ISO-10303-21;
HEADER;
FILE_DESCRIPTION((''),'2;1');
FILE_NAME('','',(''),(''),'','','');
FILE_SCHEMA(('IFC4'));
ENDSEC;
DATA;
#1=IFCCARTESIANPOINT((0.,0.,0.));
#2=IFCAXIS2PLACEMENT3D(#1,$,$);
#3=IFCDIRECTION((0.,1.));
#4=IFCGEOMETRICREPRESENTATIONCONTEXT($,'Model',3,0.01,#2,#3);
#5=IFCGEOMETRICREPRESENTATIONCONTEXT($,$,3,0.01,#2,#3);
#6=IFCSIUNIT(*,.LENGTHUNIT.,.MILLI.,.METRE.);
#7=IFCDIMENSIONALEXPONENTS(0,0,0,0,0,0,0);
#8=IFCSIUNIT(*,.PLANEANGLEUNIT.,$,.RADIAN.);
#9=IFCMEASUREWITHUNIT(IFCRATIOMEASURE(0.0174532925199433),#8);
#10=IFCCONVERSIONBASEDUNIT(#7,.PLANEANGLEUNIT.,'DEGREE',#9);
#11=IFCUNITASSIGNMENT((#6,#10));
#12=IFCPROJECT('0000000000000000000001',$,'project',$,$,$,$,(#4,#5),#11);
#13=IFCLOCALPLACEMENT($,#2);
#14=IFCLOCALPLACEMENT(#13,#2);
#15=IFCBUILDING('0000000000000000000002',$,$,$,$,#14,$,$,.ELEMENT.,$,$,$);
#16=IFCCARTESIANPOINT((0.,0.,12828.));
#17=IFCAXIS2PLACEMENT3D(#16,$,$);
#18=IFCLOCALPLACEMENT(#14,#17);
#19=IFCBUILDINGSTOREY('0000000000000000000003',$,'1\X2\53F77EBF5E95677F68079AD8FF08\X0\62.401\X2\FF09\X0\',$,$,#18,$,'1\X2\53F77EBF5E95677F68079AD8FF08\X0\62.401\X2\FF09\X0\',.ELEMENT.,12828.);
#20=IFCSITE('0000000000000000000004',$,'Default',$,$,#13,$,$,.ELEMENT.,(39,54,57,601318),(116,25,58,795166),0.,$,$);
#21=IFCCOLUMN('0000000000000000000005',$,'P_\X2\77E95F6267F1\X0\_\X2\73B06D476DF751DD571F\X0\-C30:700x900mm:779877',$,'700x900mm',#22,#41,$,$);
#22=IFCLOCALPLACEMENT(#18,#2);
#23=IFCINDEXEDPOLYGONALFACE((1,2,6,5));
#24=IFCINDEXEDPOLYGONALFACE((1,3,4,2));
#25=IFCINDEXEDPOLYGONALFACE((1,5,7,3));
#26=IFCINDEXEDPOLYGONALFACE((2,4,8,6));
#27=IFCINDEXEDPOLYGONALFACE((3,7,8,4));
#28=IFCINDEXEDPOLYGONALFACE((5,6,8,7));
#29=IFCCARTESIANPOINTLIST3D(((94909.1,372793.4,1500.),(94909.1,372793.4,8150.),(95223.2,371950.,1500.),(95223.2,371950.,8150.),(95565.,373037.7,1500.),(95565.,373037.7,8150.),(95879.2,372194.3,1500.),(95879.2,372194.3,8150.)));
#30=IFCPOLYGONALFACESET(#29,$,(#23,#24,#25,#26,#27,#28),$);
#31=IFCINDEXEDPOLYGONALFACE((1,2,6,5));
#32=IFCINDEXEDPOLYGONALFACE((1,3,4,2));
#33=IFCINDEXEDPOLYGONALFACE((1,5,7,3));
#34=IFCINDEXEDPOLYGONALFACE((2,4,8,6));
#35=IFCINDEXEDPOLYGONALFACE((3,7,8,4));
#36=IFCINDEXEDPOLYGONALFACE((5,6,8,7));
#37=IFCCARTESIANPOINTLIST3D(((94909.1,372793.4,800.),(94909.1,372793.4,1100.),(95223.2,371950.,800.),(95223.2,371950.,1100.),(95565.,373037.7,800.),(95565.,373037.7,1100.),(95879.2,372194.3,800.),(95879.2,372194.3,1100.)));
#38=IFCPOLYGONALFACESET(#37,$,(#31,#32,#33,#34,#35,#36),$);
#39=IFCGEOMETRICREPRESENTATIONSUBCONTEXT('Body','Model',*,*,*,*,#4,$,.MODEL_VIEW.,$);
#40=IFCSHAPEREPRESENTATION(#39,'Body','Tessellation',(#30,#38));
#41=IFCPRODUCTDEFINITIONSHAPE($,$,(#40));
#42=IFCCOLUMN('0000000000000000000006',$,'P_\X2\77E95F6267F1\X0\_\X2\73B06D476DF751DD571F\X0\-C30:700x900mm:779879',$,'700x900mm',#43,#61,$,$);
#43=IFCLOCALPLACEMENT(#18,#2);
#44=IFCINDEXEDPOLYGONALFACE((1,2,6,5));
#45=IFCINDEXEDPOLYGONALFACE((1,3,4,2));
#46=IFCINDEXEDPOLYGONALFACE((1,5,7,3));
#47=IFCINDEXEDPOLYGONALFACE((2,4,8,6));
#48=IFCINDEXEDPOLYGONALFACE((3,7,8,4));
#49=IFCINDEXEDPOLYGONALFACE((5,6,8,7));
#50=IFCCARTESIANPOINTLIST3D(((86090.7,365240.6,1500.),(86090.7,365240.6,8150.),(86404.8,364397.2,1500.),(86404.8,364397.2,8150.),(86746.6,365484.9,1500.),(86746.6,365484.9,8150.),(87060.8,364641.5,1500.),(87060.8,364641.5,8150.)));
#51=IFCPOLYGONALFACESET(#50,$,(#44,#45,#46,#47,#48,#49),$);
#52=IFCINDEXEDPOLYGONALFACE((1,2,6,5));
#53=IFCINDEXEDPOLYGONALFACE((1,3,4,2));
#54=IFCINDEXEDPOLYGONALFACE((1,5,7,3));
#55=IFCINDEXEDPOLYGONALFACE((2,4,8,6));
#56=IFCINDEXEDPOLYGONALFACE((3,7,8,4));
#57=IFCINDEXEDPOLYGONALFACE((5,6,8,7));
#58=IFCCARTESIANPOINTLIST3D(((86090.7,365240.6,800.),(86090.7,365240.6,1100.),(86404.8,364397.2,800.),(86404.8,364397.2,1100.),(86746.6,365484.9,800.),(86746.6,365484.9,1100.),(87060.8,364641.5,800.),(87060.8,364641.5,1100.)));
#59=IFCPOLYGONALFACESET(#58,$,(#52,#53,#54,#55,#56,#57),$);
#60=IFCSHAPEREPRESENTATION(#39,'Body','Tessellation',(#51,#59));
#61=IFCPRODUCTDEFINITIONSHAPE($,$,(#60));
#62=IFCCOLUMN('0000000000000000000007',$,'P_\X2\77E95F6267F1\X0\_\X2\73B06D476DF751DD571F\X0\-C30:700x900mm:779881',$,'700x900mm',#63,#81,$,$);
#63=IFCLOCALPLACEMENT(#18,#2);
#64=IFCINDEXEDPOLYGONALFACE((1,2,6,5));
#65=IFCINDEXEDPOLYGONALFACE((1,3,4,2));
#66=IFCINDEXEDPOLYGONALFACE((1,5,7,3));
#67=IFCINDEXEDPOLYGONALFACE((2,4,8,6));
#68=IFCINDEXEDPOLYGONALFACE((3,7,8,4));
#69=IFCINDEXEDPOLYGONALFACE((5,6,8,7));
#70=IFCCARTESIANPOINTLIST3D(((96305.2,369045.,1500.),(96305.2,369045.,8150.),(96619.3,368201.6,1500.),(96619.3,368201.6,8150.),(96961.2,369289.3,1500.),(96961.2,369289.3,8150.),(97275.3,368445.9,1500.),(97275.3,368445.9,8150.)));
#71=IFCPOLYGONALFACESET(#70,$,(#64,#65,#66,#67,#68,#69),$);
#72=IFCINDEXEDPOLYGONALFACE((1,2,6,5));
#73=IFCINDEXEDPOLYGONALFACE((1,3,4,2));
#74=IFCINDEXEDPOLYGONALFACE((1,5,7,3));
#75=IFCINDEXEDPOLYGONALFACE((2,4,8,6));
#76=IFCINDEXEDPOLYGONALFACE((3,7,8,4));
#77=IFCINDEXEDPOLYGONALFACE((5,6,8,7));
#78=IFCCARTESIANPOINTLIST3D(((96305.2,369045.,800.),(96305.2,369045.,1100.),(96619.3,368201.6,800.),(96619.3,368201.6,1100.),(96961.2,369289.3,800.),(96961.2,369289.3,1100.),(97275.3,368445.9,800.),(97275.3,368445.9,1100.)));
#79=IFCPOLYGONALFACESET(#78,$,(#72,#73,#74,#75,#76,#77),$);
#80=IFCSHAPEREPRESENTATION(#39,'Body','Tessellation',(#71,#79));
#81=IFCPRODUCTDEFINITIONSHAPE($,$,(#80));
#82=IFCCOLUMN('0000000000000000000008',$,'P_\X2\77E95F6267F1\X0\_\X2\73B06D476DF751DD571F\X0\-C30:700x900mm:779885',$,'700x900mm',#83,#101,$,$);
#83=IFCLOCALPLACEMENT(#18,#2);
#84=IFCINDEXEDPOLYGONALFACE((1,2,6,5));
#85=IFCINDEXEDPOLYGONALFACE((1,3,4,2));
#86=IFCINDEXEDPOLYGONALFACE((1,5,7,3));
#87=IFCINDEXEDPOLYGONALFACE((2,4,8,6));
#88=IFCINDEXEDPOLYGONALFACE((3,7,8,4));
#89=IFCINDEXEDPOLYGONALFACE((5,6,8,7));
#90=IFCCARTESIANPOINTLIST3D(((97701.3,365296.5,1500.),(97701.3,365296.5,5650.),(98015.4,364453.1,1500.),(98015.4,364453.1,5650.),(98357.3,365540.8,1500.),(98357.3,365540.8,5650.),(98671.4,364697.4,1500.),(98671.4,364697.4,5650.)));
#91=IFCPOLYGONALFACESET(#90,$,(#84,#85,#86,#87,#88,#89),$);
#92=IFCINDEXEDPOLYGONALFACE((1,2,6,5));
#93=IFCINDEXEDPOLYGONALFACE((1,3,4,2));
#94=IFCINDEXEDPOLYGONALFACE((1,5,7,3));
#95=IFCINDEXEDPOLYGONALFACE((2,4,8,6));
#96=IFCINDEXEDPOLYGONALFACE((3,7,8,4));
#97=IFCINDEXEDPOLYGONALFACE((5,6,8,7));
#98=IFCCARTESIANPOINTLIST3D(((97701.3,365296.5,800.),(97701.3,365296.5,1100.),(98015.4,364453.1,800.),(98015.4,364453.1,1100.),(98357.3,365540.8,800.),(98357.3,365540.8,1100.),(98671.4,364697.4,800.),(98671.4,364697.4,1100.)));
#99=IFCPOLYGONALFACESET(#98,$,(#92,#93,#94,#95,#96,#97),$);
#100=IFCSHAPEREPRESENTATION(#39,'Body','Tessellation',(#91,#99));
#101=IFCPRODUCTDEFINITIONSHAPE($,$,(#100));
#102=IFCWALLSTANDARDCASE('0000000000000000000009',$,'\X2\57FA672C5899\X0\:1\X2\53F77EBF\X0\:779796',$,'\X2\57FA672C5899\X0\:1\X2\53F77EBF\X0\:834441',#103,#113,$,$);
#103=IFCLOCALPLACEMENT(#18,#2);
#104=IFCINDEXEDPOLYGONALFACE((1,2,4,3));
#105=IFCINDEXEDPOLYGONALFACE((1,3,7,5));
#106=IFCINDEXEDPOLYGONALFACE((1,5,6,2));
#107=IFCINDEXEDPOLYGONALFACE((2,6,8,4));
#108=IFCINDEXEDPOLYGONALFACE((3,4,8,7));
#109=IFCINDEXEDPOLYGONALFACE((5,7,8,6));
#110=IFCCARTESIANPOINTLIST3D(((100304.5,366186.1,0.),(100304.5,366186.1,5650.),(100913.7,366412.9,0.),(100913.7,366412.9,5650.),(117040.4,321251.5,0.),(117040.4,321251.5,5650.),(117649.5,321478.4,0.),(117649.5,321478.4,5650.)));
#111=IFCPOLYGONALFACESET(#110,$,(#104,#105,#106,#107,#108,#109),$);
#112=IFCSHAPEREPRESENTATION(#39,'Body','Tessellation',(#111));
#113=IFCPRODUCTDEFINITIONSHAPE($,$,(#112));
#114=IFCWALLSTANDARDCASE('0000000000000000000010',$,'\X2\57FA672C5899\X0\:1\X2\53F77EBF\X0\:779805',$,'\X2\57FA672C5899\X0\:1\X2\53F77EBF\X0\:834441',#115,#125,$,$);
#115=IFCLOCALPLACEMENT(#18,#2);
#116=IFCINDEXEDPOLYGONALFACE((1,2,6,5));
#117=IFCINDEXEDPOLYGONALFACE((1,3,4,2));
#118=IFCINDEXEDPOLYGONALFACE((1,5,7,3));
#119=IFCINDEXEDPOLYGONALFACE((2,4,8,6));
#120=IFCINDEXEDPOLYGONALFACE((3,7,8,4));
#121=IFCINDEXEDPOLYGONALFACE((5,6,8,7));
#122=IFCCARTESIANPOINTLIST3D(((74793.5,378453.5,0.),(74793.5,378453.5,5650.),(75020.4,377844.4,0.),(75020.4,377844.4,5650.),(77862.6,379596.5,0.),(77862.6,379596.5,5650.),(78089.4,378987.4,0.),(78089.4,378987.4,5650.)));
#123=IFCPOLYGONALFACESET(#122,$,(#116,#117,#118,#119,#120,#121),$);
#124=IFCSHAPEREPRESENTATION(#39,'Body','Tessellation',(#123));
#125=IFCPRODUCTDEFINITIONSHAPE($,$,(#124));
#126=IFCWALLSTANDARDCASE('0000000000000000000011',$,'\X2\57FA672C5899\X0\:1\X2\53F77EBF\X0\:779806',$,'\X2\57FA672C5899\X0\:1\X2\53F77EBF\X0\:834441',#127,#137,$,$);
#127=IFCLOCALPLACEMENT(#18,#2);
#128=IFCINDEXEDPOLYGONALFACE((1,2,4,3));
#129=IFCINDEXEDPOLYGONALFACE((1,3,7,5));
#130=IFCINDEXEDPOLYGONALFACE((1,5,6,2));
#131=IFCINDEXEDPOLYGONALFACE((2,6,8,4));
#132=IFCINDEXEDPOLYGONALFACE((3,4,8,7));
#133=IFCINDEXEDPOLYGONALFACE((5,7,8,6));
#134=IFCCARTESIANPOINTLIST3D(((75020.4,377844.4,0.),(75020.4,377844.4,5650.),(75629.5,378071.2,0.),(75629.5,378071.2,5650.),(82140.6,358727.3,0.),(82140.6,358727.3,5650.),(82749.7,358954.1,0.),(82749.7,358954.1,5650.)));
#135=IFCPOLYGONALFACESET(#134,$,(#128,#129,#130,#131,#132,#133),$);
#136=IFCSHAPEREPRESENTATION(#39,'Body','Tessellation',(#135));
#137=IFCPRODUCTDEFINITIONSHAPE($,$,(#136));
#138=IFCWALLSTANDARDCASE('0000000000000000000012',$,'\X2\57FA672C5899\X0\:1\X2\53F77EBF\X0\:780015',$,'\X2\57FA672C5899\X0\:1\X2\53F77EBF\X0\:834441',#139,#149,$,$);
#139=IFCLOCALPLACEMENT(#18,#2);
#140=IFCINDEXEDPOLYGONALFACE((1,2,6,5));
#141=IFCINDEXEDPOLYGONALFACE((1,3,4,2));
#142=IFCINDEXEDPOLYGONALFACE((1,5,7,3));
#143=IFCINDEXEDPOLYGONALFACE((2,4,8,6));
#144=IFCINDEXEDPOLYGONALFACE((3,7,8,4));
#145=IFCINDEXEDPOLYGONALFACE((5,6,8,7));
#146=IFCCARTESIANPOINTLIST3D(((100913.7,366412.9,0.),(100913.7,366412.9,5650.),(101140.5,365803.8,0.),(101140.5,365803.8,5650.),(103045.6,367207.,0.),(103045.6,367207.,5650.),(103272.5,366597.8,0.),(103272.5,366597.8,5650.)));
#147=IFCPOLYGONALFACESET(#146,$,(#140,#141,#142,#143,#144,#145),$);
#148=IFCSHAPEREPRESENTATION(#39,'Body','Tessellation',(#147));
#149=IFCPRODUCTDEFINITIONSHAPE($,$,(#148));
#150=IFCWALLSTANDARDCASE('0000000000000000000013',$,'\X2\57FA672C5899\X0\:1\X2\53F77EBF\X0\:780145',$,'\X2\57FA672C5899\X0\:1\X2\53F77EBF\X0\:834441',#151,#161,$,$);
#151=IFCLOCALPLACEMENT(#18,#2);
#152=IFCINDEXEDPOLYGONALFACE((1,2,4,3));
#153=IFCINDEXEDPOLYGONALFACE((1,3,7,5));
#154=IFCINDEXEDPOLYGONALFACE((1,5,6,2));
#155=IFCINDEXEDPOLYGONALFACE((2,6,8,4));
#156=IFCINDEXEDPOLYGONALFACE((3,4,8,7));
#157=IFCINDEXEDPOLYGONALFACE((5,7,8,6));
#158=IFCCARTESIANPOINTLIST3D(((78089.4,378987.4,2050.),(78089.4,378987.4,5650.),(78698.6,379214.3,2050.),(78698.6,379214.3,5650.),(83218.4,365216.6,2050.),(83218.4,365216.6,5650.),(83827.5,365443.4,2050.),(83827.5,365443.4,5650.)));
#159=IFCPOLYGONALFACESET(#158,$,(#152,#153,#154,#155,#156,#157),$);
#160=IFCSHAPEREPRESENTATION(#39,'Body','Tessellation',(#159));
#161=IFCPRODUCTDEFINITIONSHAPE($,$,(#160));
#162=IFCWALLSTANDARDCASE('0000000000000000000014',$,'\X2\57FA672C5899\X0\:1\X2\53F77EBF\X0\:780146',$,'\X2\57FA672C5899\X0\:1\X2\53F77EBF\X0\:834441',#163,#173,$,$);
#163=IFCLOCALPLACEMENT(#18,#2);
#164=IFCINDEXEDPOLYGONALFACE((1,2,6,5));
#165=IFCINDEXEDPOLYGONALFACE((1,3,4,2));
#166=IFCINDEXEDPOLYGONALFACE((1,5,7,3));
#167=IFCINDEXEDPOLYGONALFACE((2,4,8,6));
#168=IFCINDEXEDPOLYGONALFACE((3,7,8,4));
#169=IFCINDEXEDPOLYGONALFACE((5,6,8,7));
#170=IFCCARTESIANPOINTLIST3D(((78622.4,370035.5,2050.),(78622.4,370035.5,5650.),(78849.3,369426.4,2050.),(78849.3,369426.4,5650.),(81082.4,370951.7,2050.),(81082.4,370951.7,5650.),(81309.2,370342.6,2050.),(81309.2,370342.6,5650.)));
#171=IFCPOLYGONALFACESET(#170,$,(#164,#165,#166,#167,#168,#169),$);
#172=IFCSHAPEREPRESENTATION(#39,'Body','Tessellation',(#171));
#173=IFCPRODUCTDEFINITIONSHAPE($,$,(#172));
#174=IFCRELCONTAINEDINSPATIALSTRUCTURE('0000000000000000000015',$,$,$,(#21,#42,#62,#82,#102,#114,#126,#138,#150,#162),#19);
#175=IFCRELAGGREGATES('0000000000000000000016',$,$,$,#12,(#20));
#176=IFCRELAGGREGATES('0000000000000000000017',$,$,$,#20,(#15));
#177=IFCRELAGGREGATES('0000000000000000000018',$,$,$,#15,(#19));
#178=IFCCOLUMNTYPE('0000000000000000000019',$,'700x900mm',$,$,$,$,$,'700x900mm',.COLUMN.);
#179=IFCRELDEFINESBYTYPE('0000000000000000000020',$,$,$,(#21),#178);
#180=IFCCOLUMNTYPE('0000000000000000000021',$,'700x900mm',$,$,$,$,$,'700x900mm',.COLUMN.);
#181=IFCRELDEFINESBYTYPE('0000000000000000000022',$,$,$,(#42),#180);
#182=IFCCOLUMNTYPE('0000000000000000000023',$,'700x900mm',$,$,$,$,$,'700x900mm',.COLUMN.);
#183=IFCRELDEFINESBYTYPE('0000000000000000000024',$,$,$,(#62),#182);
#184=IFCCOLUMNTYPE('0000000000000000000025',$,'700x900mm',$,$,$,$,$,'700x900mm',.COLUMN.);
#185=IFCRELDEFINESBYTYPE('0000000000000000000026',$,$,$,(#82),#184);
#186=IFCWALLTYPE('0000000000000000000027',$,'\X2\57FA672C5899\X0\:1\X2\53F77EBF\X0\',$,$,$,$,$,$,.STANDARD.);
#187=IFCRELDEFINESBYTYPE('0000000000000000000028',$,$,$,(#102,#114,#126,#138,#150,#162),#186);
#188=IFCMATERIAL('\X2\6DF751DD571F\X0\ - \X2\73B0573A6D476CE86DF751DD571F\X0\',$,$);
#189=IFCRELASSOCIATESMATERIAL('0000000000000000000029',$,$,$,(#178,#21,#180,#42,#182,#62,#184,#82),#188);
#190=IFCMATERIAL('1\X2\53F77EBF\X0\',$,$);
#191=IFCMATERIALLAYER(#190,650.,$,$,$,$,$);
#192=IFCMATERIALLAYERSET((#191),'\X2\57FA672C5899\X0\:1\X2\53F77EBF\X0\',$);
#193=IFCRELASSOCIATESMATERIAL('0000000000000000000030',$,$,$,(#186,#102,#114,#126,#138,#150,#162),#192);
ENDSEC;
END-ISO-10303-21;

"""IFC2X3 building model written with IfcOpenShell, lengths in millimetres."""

from ifc_helpers import new_model, entity, si_unit, converted_unit, direction, frame, frame_2d, origin, place, context, subcontext, project, spatial, polyline, rectangle, extrude, clip, bounded_halfspace, source, transform, mapped, material, layer, layer_set, layer_usage, type_object, type_shapes, element, save


model = new_model("IFC2X3")

# Units and contexts
model_context = context("Model", 3, precision=0.01, world=origin(), true_north=direction((0.0, 1.0)))
context_of_model = context(None, 3, precision=0.01, world=origin(), true_north=direction((0.0, 1.0)))
body_context = subcontext(model_context, "Body", "Model", "MODEL_VIEW")
ifc_project = project(units=[si_unit("LENGTHUNIT", "METRE", prefix="MILLI"), converted_unit("PLANEANGLEUNIT", "DEGREE", entity("IfcRatioMeasure", 0.0174532925199433), si_unit("PLANEANGLEUNIT", "RADIAN"), dimensions=[0, 0, 0, 0, 0, 0, 0])], contexts=[model_context, context_of_model])

# Site, building, storey
site_placement = place(None, origin())
site = spatial("IfcSite", under=ifc_project, at=site_placement, Name="Default", CompositionType="ELEMENT", RefLatitude=(39, 54, 57, 601318), RefLongitude=(116, 25, 58, 795166), RefElevation=0.0)
building_placement = place(site_placement, origin())
building = spatial("IfcBuilding", under=site, at=building_placement, CompositionType="ELEMENT")
storey_placement = place(building_placement, frame((0.0, 0.0, 12828.0)))
storey = spatial("IfcBuildingStorey", under=building, at=storey_placement, Name="1号线底板标高（62.401）", LongName="1号线底板标高（62.401）", CompositionType="ELEMENT", Elevation=12828.0)

# Columns
ifc_material_1 = material(Name="混凝土 - 现场浇注混凝土")
column_type_1 = type_object("IfcColumnType", Name="700x900mm", ElementType="700x900mm", PredefinedType="COLUMN", material=ifc_material_1)
shared_shape_1 = source(origin(), body_context, "Body", "SweptSolid", [
    extrude(rectangle(XDim=700.0, YDim=900.0, at=frame_2d((0.0, 0.0), x_axis=(1.0, 0.0))), frame((485.1, 543.9, 700.0), z_axis=(0.0, 0.0, 1.0), x_axis=(-0.937112, -0.349028, 0.0)), (0.0, 0.0, 1.0), 6650.0),
    extrude(rectangle(XDim=700.0, YDim=900.0, at=frame_2d((0.0, 0.0), x_axis=(1.0, 0.0))), frame((485.1, 543.9, 0.0), z_axis=(0.0, 0.0, 1.0), x_axis=(-0.937112, -0.349028, 0.0)), (0.0, 0.0, 1.0), 300.0),
])
type_shapes(column_type_1, [shared_shape_1])
column_1_placement = place(storey_placement, frame((94909.1, 371950.0, 800.0)))
element("IfcColumn", 1, at=column_1_placement, inside=storey, type_object=column_type_1, material=ifc_material_1, Name="P_矩形柱_现浇混凝土-C30:700x900mm:779877", ObjectType="700x900mm", context=body_context, shape_type="MappedRepresentation", body=[
    mapped(shared_shape_1, transform((0.0, 0.0, 0.0), scale=1.0)),
])
column_type_2 = type_object("IfcColumnType", Name="700x900mm", ElementType="700x900mm", PredefinedType="COLUMN", material=ifc_material_1)
shared_shape_2 = source(origin(), body_context, "Body", "SweptSolid", [
    extrude(rectangle(XDim=700.0, YDim=900.0, at=frame_2d((0.0, 0.0), x_axis=(1.0, 0.0))), frame((485.1, 543.9, 700.0), z_axis=(0.0, 0.0, 1.0), x_axis=(-0.937112, -0.349028, 0.0)), (0.0, 0.0, 1.0), 6650.0),
    extrude(rectangle(XDim=700.0, YDim=900.0, at=frame_2d((0.0, 0.0), x_axis=(1.0, 0.0))), frame((485.1, 543.9, 0.0), z_axis=(0.0, 0.0, 1.0), x_axis=(-0.937112, -0.349028, 0.0)), (0.0, 0.0, 1.0), 300.0),
])
type_shapes(column_type_2, [shared_shape_2])
column_2_placement = place(storey_placement, frame((86090.7, 364397.2, 800.0)))
element("IfcColumn", 2, at=column_2_placement, inside=storey, type_object=column_type_2, material=ifc_material_1, Name="P_矩形柱_现浇混凝土-C30:700x900mm:779879", ObjectType="700x900mm", context=body_context, shape_type="MappedRepresentation", body=[
    mapped(shared_shape_2, transform((0.0, 0.0, 0.0), scale=1.0)),
])
column_type_3 = type_object("IfcColumnType", Name="700x900mm", ElementType="700x900mm", PredefinedType="COLUMN", material=ifc_material_1)
shared_shape_3 = source(origin(), body_context, "Body", "SweptSolid", [
    extrude(rectangle(XDim=700.0, YDim=900.0, at=frame_2d((0.0, 0.0), x_axis=(1.0, 0.0))), frame((485.1, 543.9, 700.0), z_axis=(0.0, 0.0, 1.0), x_axis=(-0.937112, -0.349028, 0.0)), (0.0, 0.0, 1.0), 6650.0),
    extrude(rectangle(XDim=700.0, YDim=900.0, at=frame_2d((0.0, 0.0), x_axis=(1.0, 0.0))), frame((485.1, 543.9, 0.0), z_axis=(0.0, 0.0, 1.0), x_axis=(-0.937112, -0.349028, 0.0)), (0.0, 0.0, 1.0), 300.0),
])
type_shapes(column_type_3, [shared_shape_3])
column_3_placement = place(storey_placement, frame((96305.2, 368201.6, 800.0)))
element("IfcColumn", 3, at=column_3_placement, inside=storey, type_object=column_type_3, material=ifc_material_1, Name="P_矩形柱_现浇混凝土-C30:700x900mm:779881", ObjectType="700x900mm", context=body_context, shape_type="MappedRepresentation", body=[
    mapped(shared_shape_3, transform((0.0, 0.0, 0.0), scale=1.0)),
])
column_type_4 = type_object("IfcColumnType", Name="700x900mm", ElementType="700x900mm", PredefinedType="COLUMN", material=ifc_material_1)
shared_shape_4 = source(origin(), body_context, "Body", "SweptSolid", [
    extrude(rectangle(XDim=700.0, YDim=900.0, at=frame_2d((0.0, 0.0), x_axis=(1.0, 0.0))), frame((485.1, 543.9, 700.0), z_axis=(0.0, 0.0, 1.0), x_axis=(-0.937112, -0.349028, 0.0)), (0.0, 0.0, 1.0), 4150.0),
    extrude(rectangle(XDim=900.0, YDim=700.0, at=frame_2d((0.0, 0.0), x_axis=(1.0, 0.0))), frame((485.1, 543.9, 0.0), z_axis=(0.0, 0.0, 1.0), x_axis=(-0.349028, 0.937112, 0.0)), (0.0, 0.0, 1.0), 300.0),
])
type_shapes(column_type_4, [shared_shape_4])
column_4_placement = place(storey_placement, frame((97701.3, 364453.1, 800.0)))
element("IfcColumn", 4, at=column_4_placement, inside=storey, type_object=column_type_4, material=ifc_material_1, Name="P_矩形柱_现浇混凝土-C30:700x900mm:779885", ObjectType="700x900mm", context=body_context, shape_type="MappedRepresentation", body=[
    mapped(shared_shape_4, transform((0.0, 0.0, 0.0), scale=1.0)),
])

# Walls
ifc_material_2 = material(Name="1号线")
ifc_layer = layer(ifc_material_2, 650.0)
ifc_layer_set = layer_set([ifc_layer], Name="基本墙:1号线")
ifc_layer_usage_1 = layer_usage(ifc_layer_set, "AXIS2", "NEGATIVE", 325.0)
wall_type = type_object("IfcWallType", Name="基本墙:1号线", PredefinedType="STANDARD", material=ifc_layer_set)
wall_1_placement = place(storey_placement, frame((100609.1, 366299.5, 0.0), z_axis=(0.0, 0.0, 1.0), x_axis=(0.349028, -0.937112, 0.0)))
element("IfcWallStandardCase", 5, at=wall_1_placement, inside=storey, type_object=wall_type, material=ifc_layer_usage_1, Name="基本墙:1号线:779796", ObjectType="基本墙:1号线:834441", context=body_context, shape_type="Clipping", body=[
    clip(extrude(rectangle(XDim=47950.0, YDim=650.0, at=frame_2d((23975.0, 0.0), x_axis=(-1.0, 0.0))), origin(), (0.0, 0.0, 1.0), 5650.0), bounded_halfspace(frame((650.0, -325.0, 5650.0), z_axis=(0.0, 0.0, -1.0), x_axis=(0.0, 1.0, 0.0)), True, frame((650.0, -325.0, 5650.0)), polyline([(0.0, 0.0), (43295.0, 0.0), (43395.0, 0.0), (47300.0, 0.0), (47300.0, 650.0), (46750.0, 650.0), (700.0, 650.0), (0.0, 650.0), (0.0, 0.0)]))),
])
ifc_layer_usage_2 = layer_usage(ifc_layer_set, "AXIS2", "NEGATIVE", 325.0)
wall_2_placement = place(storey_placement, frame((77976.0, 379292.0, 0.0), z_axis=(0.0, 0.0, 1.0), x_axis=(-0.937112, -0.349028, 0.0)))
element("IfcWallStandardCase", 6, at=wall_2_placement, inside=storey, type_object=wall_type, material=ifc_layer_usage_2, Name="基本墙:1号线:779805", ObjectType="基本墙:1号线:834441", context=body_context, shape_type="SweptSolid", body=[
    extrude(rectangle(XDim=3275.0, YDim=650.0, at=frame_2d((1637.5, 0.0), x_axis=(-1.0, 0.0))), origin(), (0.0, 0.0, 1.0), 5650.0),
])
ifc_layer_usage_3 = layer_usage(ifc_layer_set, "AXIS2", "NEGATIVE", 325.0)
wall_3_placement = place(storey_placement, frame((75325.0, 377957.8, 0.0), z_axis=(0.0, 0.0, 1.0), x_axis=(0.349028, -0.937112, 0.0)))
element("IfcWallStandardCase", 7, at=wall_3_placement, inside=storey, type_object=wall_type, material=ifc_layer_usage_3, Name="基本墙:1号线:779806", ObjectType="基本墙:1号线:834441", context=body_context, shape_type="SweptSolid", body=[
    extrude(rectangle(XDim=20400.0, YDim=650.0, at=frame_2d((10200.0, 0.0), x_axis=(-1.0, 0.0))), origin(), (0.0, 0.0, 1.0), 5650.0),
])
ifc_layer_usage_4 = layer_usage(ifc_layer_set, "AXIS2", "POSITIVE", -325.0)
wall_4_placement = place(storey_placement, frame((103159.0, 366902.4, 0.0), z_axis=(0.0, 0.0, 1.0), x_axis=(-0.937112, -0.349028, 0.0)))
element("IfcWallStandardCase", 8, at=wall_4_placement, inside=storey, type_object=wall_type, material=ifc_layer_usage_4, Name="基本墙:1号线:780015", ObjectType="基本墙:1号线:834441", context=body_context, shape_type="SweptSolid", body=[
    extrude(rectangle(XDim=2275.0, YDim=650.0, at=frame_2d((1137.5, 0.0), x_axis=(-1.0, 0.0))), origin(), (0.0, 0.0, 1.0), 5650.0),
])
ifc_layer_usage_5 = layer_usage(ifc_layer_set, "AXIS2", "NEGATIVE", 325.0)
wall_5_placement = place(storey_placement, frame((83523.0, 365330.0, 2050.0), z_axis=(0.0, 0.0, 1.0), x_axis=(-0.349028, 0.937112, 0.0)))
element("IfcWallStandardCase", 9, at=wall_5_placement, inside=storey, type_object=wall_type, material=ifc_layer_usage_5, Name="基本墙:1号线:780145", ObjectType="基本墙:1号线:834441", context=body_context, shape_type="SweptSolid", body=[
    extrude(rectangle(XDim=14695.0, YDim=650.0, at=frame_2d((7347.5, 0.0), x_axis=(-1.0, 0.0))), origin(), (0.0, 0.0, 1.0), 3600.0),
])
ifc_layer_usage_6 = layer_usage(ifc_layer_set, "AXIS2", "NEGATIVE", 325.0)
wall_6_placement = place(storey_placement, frame((81195.8, 370647.1, 2050.0), z_axis=(0.0, 0.0, 1.0), x_axis=(-0.937112, -0.349028, 0.0)))
element("IfcWallStandardCase", 10, at=wall_6_placement, inside=storey, type_object=wall_type, material=ifc_layer_usage_6, Name="基本墙:1号线:780146", ObjectType="基本墙:1号线:834441", context=body_context, shape_type="SweptSolid", body=[
    extrude(rectangle(XDim=2625.0, YDim=650.0, at=frame_2d((1312.5, 0.0), x_axis=(-1.0, 0.0))), origin(), (0.0, 0.0, 1.0), 3600.0),
])

save(model, "model.ifc")
